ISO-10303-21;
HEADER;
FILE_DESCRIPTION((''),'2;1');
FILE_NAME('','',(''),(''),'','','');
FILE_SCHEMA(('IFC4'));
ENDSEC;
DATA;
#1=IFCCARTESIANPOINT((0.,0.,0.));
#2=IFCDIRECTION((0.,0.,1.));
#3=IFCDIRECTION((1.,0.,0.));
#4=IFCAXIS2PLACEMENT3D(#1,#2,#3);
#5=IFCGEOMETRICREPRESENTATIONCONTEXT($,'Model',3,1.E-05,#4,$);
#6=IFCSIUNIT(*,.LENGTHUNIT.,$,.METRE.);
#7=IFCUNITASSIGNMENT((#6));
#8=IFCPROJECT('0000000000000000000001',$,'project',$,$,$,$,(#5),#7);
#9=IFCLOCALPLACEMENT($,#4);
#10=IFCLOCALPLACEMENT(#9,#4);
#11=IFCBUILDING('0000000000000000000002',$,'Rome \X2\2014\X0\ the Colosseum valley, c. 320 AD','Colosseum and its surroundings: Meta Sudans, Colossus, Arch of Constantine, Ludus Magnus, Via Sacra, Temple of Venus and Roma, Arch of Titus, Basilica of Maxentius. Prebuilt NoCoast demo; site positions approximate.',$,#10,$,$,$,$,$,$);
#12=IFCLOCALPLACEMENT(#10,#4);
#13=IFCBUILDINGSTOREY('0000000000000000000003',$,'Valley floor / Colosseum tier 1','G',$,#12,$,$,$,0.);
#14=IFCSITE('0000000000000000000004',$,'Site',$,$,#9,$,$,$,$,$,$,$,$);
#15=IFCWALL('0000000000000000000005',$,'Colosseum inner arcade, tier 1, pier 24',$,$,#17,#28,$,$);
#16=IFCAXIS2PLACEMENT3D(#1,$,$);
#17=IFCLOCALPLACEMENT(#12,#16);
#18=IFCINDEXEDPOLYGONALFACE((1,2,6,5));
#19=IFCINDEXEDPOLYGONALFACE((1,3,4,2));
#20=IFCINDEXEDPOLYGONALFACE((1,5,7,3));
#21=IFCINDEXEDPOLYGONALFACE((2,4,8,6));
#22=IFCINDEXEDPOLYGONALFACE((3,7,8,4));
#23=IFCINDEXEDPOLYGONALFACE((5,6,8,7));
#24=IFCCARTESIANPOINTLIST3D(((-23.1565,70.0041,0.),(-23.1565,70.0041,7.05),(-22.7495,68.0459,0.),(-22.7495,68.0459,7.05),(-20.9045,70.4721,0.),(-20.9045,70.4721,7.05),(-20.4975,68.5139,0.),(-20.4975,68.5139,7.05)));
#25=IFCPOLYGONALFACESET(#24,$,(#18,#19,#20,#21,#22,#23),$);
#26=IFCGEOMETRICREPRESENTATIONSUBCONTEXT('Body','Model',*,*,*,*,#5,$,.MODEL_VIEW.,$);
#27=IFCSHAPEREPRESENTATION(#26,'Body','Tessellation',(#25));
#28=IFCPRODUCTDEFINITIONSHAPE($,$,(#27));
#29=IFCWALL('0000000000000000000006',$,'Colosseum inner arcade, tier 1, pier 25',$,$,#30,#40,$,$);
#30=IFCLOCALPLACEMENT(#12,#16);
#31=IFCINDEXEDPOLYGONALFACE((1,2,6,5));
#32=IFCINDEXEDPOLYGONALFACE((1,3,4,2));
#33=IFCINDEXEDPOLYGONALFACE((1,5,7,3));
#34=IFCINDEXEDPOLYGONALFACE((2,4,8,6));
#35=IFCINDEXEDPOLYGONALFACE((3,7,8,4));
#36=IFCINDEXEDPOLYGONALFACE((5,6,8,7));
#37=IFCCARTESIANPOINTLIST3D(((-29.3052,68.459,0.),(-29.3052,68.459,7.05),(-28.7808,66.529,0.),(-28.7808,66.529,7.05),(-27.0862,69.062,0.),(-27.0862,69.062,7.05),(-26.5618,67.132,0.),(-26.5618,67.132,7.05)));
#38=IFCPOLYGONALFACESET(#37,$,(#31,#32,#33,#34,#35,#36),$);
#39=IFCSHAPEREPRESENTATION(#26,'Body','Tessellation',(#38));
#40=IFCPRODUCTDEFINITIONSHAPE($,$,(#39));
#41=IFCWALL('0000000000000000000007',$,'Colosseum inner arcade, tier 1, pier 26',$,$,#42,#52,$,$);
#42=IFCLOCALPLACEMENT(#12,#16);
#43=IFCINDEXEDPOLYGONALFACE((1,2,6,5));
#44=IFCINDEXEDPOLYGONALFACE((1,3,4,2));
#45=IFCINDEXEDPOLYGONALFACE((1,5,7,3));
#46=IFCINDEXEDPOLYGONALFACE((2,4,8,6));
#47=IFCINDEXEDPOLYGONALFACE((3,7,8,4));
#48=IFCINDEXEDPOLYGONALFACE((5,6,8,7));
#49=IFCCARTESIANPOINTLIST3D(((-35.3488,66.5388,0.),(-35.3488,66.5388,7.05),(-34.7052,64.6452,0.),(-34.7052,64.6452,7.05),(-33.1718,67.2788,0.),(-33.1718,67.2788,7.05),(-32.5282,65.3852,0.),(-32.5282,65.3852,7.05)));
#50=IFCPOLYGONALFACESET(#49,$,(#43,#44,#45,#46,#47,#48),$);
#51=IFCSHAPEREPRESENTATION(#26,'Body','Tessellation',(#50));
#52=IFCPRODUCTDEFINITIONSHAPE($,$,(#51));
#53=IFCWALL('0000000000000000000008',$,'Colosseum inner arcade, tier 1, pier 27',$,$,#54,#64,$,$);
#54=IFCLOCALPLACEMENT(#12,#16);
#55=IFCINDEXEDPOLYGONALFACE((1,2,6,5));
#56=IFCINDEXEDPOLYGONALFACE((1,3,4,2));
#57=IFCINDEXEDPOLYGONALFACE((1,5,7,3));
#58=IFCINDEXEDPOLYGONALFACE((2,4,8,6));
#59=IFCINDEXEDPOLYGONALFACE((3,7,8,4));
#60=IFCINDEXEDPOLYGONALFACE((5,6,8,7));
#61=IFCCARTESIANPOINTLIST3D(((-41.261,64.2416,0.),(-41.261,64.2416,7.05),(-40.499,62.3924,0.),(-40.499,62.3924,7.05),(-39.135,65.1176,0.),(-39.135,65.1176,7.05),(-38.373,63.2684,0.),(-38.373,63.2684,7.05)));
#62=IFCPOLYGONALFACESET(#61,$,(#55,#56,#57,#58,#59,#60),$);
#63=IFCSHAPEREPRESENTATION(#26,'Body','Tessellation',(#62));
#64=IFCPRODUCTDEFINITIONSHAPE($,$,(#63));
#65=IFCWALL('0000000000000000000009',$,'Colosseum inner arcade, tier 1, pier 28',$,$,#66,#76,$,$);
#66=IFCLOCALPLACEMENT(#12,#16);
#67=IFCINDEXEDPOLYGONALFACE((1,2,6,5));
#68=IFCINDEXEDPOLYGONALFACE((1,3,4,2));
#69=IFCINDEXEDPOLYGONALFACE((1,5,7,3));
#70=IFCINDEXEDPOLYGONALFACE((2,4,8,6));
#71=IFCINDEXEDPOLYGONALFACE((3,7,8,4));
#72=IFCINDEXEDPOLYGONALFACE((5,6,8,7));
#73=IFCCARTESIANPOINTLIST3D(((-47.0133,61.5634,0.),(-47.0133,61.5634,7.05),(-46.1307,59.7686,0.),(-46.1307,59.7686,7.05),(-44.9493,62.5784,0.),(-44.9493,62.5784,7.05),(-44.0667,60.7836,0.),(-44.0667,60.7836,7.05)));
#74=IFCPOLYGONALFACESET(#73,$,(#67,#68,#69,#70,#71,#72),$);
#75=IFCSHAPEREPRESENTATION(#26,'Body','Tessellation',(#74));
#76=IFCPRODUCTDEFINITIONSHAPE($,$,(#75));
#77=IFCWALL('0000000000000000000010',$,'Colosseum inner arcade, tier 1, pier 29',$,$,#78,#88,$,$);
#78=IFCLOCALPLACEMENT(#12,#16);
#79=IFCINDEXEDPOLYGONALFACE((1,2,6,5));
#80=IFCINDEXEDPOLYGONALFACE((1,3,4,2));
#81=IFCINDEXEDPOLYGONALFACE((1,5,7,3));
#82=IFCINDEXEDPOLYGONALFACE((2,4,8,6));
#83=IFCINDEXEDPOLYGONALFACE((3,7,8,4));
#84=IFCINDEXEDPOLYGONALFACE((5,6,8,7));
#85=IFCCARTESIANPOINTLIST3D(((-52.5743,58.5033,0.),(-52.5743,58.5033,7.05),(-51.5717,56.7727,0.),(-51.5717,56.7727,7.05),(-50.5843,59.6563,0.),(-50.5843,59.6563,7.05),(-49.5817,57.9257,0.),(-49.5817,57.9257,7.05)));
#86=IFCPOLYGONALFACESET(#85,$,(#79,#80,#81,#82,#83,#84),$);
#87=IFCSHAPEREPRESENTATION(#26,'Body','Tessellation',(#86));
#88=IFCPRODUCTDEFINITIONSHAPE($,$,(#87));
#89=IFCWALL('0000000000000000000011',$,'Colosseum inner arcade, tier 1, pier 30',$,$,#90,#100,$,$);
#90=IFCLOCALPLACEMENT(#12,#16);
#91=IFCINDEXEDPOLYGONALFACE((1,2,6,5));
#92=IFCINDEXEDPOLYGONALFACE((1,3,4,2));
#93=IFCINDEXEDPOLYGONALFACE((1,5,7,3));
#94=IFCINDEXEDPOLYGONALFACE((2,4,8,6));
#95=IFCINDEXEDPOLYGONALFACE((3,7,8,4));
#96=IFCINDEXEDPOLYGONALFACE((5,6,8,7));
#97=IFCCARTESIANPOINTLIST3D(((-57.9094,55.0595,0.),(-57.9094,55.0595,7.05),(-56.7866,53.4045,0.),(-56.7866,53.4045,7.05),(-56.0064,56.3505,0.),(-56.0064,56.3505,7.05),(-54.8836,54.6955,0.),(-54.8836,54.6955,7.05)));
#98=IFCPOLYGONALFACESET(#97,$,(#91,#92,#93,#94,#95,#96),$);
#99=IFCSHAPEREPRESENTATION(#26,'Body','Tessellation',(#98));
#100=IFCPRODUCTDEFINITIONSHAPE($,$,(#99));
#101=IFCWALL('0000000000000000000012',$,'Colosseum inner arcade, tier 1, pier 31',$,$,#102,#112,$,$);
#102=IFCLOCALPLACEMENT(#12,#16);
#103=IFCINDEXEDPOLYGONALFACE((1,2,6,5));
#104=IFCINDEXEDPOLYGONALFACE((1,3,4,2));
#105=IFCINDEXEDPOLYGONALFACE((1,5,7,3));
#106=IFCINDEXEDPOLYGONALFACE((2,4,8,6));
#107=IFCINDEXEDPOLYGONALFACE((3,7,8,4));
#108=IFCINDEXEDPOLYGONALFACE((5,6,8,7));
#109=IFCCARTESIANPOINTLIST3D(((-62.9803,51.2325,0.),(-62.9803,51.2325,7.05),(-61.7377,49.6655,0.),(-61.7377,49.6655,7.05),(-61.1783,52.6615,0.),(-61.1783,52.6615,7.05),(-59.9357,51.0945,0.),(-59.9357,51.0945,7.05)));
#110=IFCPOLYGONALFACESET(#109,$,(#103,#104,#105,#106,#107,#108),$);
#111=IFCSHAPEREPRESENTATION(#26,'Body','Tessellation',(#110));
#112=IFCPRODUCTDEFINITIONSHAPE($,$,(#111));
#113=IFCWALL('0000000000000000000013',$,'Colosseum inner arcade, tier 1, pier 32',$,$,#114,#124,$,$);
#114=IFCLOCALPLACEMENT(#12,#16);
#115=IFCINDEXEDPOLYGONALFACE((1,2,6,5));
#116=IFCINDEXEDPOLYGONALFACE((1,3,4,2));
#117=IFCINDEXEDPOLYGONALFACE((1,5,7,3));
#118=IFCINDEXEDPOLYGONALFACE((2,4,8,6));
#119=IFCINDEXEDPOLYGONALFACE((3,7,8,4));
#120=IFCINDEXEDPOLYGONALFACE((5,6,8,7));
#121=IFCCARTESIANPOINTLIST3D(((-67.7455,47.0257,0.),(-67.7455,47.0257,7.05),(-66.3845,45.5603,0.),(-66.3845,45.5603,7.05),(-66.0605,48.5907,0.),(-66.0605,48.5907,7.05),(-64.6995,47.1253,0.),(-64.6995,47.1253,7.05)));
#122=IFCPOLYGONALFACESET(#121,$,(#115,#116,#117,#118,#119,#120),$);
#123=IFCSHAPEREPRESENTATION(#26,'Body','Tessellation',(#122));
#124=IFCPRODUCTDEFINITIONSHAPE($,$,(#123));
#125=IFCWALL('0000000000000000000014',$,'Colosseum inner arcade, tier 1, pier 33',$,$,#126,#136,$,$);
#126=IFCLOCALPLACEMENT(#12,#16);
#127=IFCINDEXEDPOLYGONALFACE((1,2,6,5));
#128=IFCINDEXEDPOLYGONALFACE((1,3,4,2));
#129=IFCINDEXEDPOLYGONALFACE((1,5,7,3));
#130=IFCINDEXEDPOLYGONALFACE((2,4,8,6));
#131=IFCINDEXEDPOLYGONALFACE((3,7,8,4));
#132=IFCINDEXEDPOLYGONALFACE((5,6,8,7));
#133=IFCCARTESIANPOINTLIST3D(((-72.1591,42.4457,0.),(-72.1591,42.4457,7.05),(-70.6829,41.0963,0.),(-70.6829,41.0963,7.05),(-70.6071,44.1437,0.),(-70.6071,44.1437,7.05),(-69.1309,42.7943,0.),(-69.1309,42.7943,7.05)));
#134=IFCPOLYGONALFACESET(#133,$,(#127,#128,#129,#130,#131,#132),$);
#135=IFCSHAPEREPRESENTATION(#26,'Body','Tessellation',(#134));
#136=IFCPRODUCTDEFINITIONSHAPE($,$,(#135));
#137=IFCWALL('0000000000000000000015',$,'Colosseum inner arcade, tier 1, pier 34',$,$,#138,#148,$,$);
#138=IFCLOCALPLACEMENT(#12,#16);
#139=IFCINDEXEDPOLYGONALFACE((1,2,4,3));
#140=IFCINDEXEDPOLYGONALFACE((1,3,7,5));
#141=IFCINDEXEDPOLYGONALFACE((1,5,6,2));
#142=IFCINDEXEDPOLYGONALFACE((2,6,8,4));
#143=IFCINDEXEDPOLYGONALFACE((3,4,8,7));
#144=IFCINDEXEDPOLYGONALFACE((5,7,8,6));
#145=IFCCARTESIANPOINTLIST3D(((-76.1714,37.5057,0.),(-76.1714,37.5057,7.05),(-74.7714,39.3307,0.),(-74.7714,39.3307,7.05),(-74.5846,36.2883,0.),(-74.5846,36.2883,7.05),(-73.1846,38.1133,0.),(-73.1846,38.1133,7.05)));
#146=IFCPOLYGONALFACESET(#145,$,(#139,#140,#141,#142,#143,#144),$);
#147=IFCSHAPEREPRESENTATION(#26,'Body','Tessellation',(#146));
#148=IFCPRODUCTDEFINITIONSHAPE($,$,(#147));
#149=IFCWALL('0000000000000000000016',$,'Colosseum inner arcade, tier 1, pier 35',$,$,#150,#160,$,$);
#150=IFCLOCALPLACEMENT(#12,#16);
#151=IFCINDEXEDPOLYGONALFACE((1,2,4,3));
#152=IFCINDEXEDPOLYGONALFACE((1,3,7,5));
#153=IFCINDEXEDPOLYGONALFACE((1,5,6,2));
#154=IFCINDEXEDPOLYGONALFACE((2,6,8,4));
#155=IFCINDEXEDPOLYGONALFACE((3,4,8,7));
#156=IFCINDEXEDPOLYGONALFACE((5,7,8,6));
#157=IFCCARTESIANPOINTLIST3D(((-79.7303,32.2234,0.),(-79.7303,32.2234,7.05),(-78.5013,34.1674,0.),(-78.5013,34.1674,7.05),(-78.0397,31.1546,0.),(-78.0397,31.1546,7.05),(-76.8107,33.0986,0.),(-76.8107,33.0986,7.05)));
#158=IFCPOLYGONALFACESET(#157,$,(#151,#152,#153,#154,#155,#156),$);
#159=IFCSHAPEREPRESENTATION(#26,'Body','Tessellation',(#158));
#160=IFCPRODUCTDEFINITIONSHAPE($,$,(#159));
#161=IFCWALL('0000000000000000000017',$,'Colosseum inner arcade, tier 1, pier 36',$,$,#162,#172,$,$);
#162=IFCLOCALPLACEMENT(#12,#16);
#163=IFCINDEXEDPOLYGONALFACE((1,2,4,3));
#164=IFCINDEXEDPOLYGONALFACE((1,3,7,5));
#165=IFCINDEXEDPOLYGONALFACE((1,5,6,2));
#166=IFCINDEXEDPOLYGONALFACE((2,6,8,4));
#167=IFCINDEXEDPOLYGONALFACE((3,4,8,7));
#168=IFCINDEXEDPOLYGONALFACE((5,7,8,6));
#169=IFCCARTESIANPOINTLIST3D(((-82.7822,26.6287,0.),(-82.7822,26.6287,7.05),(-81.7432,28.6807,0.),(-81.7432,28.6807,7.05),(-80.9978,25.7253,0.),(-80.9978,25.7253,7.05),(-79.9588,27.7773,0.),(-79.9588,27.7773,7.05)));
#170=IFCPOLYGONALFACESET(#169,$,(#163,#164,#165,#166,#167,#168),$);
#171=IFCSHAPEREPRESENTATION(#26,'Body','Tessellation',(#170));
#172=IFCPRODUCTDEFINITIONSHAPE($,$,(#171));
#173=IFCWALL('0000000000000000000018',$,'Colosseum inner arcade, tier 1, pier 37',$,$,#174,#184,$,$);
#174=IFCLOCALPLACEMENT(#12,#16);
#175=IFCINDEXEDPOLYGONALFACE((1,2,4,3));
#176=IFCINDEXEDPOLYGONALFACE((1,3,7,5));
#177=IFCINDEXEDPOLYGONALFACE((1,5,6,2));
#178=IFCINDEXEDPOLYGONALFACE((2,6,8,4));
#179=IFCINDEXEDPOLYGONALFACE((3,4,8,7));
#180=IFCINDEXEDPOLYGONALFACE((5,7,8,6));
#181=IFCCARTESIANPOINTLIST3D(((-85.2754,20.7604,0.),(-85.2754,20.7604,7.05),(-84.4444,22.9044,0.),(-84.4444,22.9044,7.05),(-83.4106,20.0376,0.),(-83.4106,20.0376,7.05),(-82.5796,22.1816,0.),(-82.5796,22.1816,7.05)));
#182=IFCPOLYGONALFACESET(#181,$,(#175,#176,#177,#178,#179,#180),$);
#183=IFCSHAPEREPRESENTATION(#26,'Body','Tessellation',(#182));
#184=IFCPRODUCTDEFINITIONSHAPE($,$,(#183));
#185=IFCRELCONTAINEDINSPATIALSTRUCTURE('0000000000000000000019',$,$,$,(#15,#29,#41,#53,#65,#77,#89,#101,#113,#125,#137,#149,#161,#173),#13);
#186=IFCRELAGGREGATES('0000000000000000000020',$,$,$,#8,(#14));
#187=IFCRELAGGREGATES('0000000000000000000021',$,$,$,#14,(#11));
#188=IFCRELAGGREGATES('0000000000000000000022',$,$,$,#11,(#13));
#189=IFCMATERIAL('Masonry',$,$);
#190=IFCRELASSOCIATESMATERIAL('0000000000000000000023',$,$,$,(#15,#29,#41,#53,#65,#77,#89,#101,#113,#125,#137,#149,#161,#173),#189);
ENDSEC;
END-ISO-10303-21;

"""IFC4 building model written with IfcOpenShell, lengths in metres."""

from ifc_helpers import new_model, si_unit, frame, origin_with_axes, place, context, subcontext, project, spatial, indexed_curve, outline, extrude, material, element, save


model = new_model("IFC4")

# Units and contexts
model_context = context("Model", 3, precision=1e-05, world=origin_with_axes())
body_context = subcontext(model_context, "Body", "Model", "MODEL_VIEW")
ifc_project = project(units=[si_unit("LENGTHUNIT", "METRE")], contexts=[model_context])

# Site, building, storey
site_placement = place(None, origin_with_axes())
site = spatial("IfcSite", under=ifc_project, at=site_placement, Name="Site")
building_placement = place(site_placement, origin_with_axes())
building = spatial("IfcBuilding", under=site, at=building_placement, Name="Rome — the Colosseum valley, c. 320 AD", Description="Colosseum and its surroundings: Meta Sudans, Colossus, Arch of Constantine, Ludus Magnus, Via Sacra, Temple of Venus and Roma, Arch of Titus, Basilica of Maxentius. Prebuilt NoCoast demo; site positions approximate.")
storey_placement = place(building_placement, origin_with_axes())
storey = spatial("IfcBuildingStorey", under=building, at=storey_placement, Name="Valley floor / Colosseum tier 1", Description="G", Elevation=0.0)

# Walls
ifc_material = material(Name="Masonry")
wall_1_placement = place(storey_placement, frame((-20.701, 69.493, 0.0), z_axis=(0.0, 0.0, 1.0), x_axis=(-0.979082, -0.203468, 0.0)))
element("IfcWall", 1, at=wall_1_placement, inside=storey, material=ifc_material, Name="Colosseum inner arcade, tier 1, pier 24", context=body_context, shape_type="SweptSolid", body=[
    extrude(outline(indexed_curve([(0.0, 0.0), (0.0, 2.0), (2.3001, 2.0), (2.3001, 0.0), (0.0, 0.0)], self_intersect=False)), frame((0.0, -1.0, 0.0), z_axis=(0.0, 0.0, 1.0), x_axis=(1.0, 0.0, 0.0)), (0.0, 0.0, 1.0), 7.05),
])
wall_2_placement = place(storey_placement, frame((-26.824, 68.097, 0.0), z_axis=(0.0, 0.0, 1.0), x_axis=(-0.965004, -0.262234, 0.0)))
element("IfcWall", 2, at=wall_2_placement, inside=storey, material=ifc_material, Name="Colosseum inner arcade, tier 1, pier 25", context=body_context, shape_type="SweptSolid", body=[
    extrude(outline(indexed_curve([(0.0, 0.0), (0.0, 2.0), (2.2995, 2.0), (2.2995, 0.0), (0.0, 0.0)], self_intersect=False)), frame((0.0, -1.0, 0.0), z_axis=(0.0, 0.0, 1.0), x_axis=(1.0, 0.0, 0.0)), (0.0, 0.0, 1.0), 7.05),
])
wall_3_placement = place(storey_placement, frame((-32.85, 66.332, 0.0), z_axis=(0.0, 0.0, 1.0), x_axis=(-0.946797, -0.321833, 0.0)))
element("IfcWall", 3, at=wall_3_placement, inside=storey, material=ifc_material, Name="Colosseum inner arcade, tier 1, pier 26", context=body_context, shape_type="SweptSolid", body=[
    extrude(outline(indexed_curve([(0.0, 0.0), (0.0, 2.0), (2.2993, 2.0), (2.2993, 0.0), (0.0, 0.0)], self_intersect=False)), frame((0.0, -1.0, 0.0), z_axis=(0.0, 0.0, 1.0), x_axis=(1.0, 0.0, 0.0)), (0.0, 0.0, 1.0), 7.05),
])
wall_4_placement = place(storey_placement, frame((-38.754, 64.193, 0.0), z_axis=(0.0, 0.0, 1.0), x_axis=(-0.924588, -0.380969, 0.0)))
element("IfcWall", 4, at=wall_4_placement, inside=storey, material=ifc_material, Name="Colosseum inner arcade, tier 1, pier 27", context=body_context, shape_type="SweptSolid", body=[
    extrude(outline(indexed_curve([(0.0, 0.0), (0.0, 2.0), (2.2994, 2.0), (2.2994, 0.0), (0.0, 0.0)], self_intersect=False)), frame((0.0, -1.0, 0.0), z_axis=(0.0, 0.0, 1.0), x_axis=(1.0, 0.0, 0.0)), (0.0, 0.0, 1.0), 7.05),
])
wall_5_placement = place(storey_placement, frame((-44.508, 61.681, 0.0), z_axis=(0.0, 0.0, 1.0), x_axis=(-0.897364, -0.441291, 0.0)))
element("IfcWall", 5, at=wall_5_placement, inside=storey, material=ifc_material, Name="Colosseum inner arcade, tier 1, pier 28", context=body_context, shape_type="SweptSolid", body=[
    extrude(outline(indexed_curve([(0.0, 0.0), (0.0, 2.0), (2.3001, 2.0), (2.3001, 0.0), (0.0, 0.0)], self_intersect=False)), frame((0.0, -1.0, 0.0), z_axis=(0.0, 0.0, 1.0), x_axis=(1.0, 0.0, 0.0)), (0.0, 0.0, 1.0), 7.05),
])
wall_6_placement = place(storey_placement, frame((-50.083, 58.791, 0.0), z_axis=(0.0, 0.0, 1.0), x_axis=(-0.865258, -0.501328, 0.0)))
element("IfcWall", 6, at=wall_6_placement, inside=storey, material=ifc_material, Name="Colosseum inner arcade, tier 1, pier 29", context=body_context, shape_type="SweptSolid", body=[
    extrude(outline(indexed_curve([(0.0, 0.0), (0.0, 2.0), (2.2999, 2.0), (2.2999, 0.0), (0.0, 0.0)], self_intersect=False)), frame((0.0, -1.0, 0.0), z_axis=(0.0, 0.0, 1.0), x_axis=(1.0, 0.0, 0.0)), (0.0, 0.0, 1.0), 7.05),
])
wall_7_placement = place(storey_placement, frame((-55.445, 55.523, 0.0), z_axis=(0.0, 0.0, 1.0), x_axis=(-0.827541, -0.561406, 0.0)))
element("IfcWall", 7, at=wall_7_placement, inside=storey, material=ifc_material, Name="Colosseum inner arcade, tier 1, pier 30", context=body_context, shape_type="SweptSolid", body=[
    extrude(outline(indexed_curve([(0.0, 0.0), (0.0, 2.0), (2.2996, 2.0), (2.2996, 0.0), (0.0, 0.0)], self_intersect=False)), frame((0.0, -1.0, 0.0), z_axis=(0.0, 0.0, 1.0), x_axis=(1.0, 0.0, 0.0)), (0.0, 0.0, 1.0), 7.05),
])
wall_8_placement = place(storey_placement, frame((-60.557, 51.878, 0.0), z_axis=(0.0, 0.0, 1.0), x_axis=(-0.783534, -0.621349, 0.0)))
element("IfcWall", 8, at=wall_8_placement, inside=storey, material=ifc_material, Name="Colosseum inner arcade, tier 1, pier 31", context=body_context, shape_type="SweptSolid", body=[
    extrude(outline(indexed_curve([(0.0, 0.0), (0.0, 2.0), (2.2998, 2.0), (2.2998, 0.0), (0.0, 0.0)], self_intersect=False)), frame((0.0, -1.0, 0.0), z_axis=(0.0, 0.0, 1.0), x_axis=(1.0, 0.0, 0.0)), (0.0, 0.0, 1.0), 7.05),
])
wall_9_placement = place(storey_placement, frame((-65.38, 47.858, 0.0), z_axis=(0.0, 0.0, 1.0), x_axis=(-0.732716, -0.680534, 0.0)))
element("IfcWall", 9, at=wall_9_placement, inside=storey, material=ifc_material, Name="Colosseum inner arcade, tier 1, pier 32", context=body_context, shape_type="SweptSolid", body=[
    extrude(outline(indexed_curve([(0.0, 0.0), (0.0, 2.0), (2.2997, 2.0), (2.2997, 0.0), (0.0, 0.0)], self_intersect=False)), frame((0.0, -1.0, 0.0), z_axis=(0.0, 0.0, 1.0), x_axis=(1.0, 0.0, 0.0)), (0.0, 0.0, 1.0), 7.05),
])
wall_10_placement = place(storey_placement, frame((-69.869, 43.469, 0.0), z_axis=(0.0, 0.0, 1.0), x_axis=(-0.674661, -0.738128, 0.0)))
element("IfcWall", 10, at=wall_10_placement, inside=storey, material=ifc_material, Name="Colosseum inner arcade, tier 1, pier 33", context=body_context, shape_type="SweptSolid", body=[
    extrude(outline(indexed_curve([(0.0, 0.0), (0.0, 2.0), (2.3004, 2.0), (2.3004, 0.0), (0.0, 0.0)], self_intersect=False)), frame((0.0, -1.0, 0.0), z_axis=(0.0, 0.0, 1.0), x_axis=(1.0, 0.0, 0.0)), (0.0, 0.0, 1.0), 7.05),
])
wall_11_placement = place(storey_placement, frame((-73.978, 38.722, 0.0), z_axis=(0.0, 0.0, 1.0), x_axis=(-0.60866, -0.793431, 0.0)))
element("IfcWall", 11, at=wall_11_placement, inside=storey, material=ifc_material, Name="Colosseum inner arcade, tier 1, pier 34", context=body_context, shape_type="SweptSolid", body=[
    extrude(outline(indexed_curve([(0.0, 0.0), (0.0, 2.0), (2.3001, 2.0), (2.3001, 0.0), (0.0, 0.0)], self_intersect=False)), frame((0.0, -1.0, 0.0), z_axis=(0.0, 0.0, 1.0), x_axis=(1.0, 0.0, 0.0)), (0.0, 0.0, 1.0), 7.05),
])
wall_12_placement = place(storey_placement, frame((-77.656, 33.633, 0.0), z_axis=(0.0, 0.0, 1.0), x_axis=(-0.534369, -0.845251, 0.0)))
element("IfcWall", 12, at=wall_12_placement, inside=storey, material=ifc_material, Name="Colosseum inner arcade, tier 1, pier 35", context=body_context, shape_type="SweptSolid", body=[
    extrude(outline(indexed_curve([(0.0, 0.0), (0.0, 2.0), (2.2999, 2.0), (2.2999, 0.0), (0.0, 0.0)], self_intersect=False)), frame((0.0, -1.0, 0.0), z_axis=(0.0, 0.0, 1.0), x_axis=(1.0, 0.0, 0.0)), (0.0, 0.0, 1.0), 7.05),
])
wall_13_placement = place(storey_placement, frame((-80.851, 28.229, 0.0), z_axis=(0.0, 0.0, 1.0), x_axis=(-0.45173, -0.892155, 0.0)))
element("IfcWall", 13, at=wall_13_placement, inside=storey, material=ifc_material, Name="Colosseum inner arcade, tier 1, pier 36", context=body_context, shape_type="SweptSolid", body=[
    extrude(outline(indexed_curve([(0.0, 0.0), (0.0, 2.0), (2.3, 2.0), (2.3, 0.0), (0.0, 0.0)], self_intersect=False)), frame((0.0, -1.0, 0.0), z_axis=(0.0, 0.0, 1.0), x_axis=(1.0, 0.0, 0.0)), (0.0, 0.0, 1.0), 7.05),
])
wall_14_placement = place(storey_placement, frame((-83.512, 22.543, 0.0), z_axis=(0.0, 0.0, 1.0), x_axis=(-0.361397, -0.932412, 0.0)))
element("IfcWall", 14, at=wall_14_placement, inside=storey, material=ifc_material, Name="Colosseum inner arcade, tier 1, pier 37", context=body_context, shape_type="SweptSolid", body=[
    extrude(outline(indexed_curve([(0.0, 0.0), (0.0, 2.0), (2.2994, 2.0), (2.2994, 0.0), (0.0, 0.0)], self_intersect=False)), frame((0.0, -1.0, 0.0), z_axis=(0.0, 0.0, 1.0), x_axis=(1.0, 0.0, 0.0)), (0.0, 0.0, 1.0), 7.05),
])

save(model, "model.ifc")
